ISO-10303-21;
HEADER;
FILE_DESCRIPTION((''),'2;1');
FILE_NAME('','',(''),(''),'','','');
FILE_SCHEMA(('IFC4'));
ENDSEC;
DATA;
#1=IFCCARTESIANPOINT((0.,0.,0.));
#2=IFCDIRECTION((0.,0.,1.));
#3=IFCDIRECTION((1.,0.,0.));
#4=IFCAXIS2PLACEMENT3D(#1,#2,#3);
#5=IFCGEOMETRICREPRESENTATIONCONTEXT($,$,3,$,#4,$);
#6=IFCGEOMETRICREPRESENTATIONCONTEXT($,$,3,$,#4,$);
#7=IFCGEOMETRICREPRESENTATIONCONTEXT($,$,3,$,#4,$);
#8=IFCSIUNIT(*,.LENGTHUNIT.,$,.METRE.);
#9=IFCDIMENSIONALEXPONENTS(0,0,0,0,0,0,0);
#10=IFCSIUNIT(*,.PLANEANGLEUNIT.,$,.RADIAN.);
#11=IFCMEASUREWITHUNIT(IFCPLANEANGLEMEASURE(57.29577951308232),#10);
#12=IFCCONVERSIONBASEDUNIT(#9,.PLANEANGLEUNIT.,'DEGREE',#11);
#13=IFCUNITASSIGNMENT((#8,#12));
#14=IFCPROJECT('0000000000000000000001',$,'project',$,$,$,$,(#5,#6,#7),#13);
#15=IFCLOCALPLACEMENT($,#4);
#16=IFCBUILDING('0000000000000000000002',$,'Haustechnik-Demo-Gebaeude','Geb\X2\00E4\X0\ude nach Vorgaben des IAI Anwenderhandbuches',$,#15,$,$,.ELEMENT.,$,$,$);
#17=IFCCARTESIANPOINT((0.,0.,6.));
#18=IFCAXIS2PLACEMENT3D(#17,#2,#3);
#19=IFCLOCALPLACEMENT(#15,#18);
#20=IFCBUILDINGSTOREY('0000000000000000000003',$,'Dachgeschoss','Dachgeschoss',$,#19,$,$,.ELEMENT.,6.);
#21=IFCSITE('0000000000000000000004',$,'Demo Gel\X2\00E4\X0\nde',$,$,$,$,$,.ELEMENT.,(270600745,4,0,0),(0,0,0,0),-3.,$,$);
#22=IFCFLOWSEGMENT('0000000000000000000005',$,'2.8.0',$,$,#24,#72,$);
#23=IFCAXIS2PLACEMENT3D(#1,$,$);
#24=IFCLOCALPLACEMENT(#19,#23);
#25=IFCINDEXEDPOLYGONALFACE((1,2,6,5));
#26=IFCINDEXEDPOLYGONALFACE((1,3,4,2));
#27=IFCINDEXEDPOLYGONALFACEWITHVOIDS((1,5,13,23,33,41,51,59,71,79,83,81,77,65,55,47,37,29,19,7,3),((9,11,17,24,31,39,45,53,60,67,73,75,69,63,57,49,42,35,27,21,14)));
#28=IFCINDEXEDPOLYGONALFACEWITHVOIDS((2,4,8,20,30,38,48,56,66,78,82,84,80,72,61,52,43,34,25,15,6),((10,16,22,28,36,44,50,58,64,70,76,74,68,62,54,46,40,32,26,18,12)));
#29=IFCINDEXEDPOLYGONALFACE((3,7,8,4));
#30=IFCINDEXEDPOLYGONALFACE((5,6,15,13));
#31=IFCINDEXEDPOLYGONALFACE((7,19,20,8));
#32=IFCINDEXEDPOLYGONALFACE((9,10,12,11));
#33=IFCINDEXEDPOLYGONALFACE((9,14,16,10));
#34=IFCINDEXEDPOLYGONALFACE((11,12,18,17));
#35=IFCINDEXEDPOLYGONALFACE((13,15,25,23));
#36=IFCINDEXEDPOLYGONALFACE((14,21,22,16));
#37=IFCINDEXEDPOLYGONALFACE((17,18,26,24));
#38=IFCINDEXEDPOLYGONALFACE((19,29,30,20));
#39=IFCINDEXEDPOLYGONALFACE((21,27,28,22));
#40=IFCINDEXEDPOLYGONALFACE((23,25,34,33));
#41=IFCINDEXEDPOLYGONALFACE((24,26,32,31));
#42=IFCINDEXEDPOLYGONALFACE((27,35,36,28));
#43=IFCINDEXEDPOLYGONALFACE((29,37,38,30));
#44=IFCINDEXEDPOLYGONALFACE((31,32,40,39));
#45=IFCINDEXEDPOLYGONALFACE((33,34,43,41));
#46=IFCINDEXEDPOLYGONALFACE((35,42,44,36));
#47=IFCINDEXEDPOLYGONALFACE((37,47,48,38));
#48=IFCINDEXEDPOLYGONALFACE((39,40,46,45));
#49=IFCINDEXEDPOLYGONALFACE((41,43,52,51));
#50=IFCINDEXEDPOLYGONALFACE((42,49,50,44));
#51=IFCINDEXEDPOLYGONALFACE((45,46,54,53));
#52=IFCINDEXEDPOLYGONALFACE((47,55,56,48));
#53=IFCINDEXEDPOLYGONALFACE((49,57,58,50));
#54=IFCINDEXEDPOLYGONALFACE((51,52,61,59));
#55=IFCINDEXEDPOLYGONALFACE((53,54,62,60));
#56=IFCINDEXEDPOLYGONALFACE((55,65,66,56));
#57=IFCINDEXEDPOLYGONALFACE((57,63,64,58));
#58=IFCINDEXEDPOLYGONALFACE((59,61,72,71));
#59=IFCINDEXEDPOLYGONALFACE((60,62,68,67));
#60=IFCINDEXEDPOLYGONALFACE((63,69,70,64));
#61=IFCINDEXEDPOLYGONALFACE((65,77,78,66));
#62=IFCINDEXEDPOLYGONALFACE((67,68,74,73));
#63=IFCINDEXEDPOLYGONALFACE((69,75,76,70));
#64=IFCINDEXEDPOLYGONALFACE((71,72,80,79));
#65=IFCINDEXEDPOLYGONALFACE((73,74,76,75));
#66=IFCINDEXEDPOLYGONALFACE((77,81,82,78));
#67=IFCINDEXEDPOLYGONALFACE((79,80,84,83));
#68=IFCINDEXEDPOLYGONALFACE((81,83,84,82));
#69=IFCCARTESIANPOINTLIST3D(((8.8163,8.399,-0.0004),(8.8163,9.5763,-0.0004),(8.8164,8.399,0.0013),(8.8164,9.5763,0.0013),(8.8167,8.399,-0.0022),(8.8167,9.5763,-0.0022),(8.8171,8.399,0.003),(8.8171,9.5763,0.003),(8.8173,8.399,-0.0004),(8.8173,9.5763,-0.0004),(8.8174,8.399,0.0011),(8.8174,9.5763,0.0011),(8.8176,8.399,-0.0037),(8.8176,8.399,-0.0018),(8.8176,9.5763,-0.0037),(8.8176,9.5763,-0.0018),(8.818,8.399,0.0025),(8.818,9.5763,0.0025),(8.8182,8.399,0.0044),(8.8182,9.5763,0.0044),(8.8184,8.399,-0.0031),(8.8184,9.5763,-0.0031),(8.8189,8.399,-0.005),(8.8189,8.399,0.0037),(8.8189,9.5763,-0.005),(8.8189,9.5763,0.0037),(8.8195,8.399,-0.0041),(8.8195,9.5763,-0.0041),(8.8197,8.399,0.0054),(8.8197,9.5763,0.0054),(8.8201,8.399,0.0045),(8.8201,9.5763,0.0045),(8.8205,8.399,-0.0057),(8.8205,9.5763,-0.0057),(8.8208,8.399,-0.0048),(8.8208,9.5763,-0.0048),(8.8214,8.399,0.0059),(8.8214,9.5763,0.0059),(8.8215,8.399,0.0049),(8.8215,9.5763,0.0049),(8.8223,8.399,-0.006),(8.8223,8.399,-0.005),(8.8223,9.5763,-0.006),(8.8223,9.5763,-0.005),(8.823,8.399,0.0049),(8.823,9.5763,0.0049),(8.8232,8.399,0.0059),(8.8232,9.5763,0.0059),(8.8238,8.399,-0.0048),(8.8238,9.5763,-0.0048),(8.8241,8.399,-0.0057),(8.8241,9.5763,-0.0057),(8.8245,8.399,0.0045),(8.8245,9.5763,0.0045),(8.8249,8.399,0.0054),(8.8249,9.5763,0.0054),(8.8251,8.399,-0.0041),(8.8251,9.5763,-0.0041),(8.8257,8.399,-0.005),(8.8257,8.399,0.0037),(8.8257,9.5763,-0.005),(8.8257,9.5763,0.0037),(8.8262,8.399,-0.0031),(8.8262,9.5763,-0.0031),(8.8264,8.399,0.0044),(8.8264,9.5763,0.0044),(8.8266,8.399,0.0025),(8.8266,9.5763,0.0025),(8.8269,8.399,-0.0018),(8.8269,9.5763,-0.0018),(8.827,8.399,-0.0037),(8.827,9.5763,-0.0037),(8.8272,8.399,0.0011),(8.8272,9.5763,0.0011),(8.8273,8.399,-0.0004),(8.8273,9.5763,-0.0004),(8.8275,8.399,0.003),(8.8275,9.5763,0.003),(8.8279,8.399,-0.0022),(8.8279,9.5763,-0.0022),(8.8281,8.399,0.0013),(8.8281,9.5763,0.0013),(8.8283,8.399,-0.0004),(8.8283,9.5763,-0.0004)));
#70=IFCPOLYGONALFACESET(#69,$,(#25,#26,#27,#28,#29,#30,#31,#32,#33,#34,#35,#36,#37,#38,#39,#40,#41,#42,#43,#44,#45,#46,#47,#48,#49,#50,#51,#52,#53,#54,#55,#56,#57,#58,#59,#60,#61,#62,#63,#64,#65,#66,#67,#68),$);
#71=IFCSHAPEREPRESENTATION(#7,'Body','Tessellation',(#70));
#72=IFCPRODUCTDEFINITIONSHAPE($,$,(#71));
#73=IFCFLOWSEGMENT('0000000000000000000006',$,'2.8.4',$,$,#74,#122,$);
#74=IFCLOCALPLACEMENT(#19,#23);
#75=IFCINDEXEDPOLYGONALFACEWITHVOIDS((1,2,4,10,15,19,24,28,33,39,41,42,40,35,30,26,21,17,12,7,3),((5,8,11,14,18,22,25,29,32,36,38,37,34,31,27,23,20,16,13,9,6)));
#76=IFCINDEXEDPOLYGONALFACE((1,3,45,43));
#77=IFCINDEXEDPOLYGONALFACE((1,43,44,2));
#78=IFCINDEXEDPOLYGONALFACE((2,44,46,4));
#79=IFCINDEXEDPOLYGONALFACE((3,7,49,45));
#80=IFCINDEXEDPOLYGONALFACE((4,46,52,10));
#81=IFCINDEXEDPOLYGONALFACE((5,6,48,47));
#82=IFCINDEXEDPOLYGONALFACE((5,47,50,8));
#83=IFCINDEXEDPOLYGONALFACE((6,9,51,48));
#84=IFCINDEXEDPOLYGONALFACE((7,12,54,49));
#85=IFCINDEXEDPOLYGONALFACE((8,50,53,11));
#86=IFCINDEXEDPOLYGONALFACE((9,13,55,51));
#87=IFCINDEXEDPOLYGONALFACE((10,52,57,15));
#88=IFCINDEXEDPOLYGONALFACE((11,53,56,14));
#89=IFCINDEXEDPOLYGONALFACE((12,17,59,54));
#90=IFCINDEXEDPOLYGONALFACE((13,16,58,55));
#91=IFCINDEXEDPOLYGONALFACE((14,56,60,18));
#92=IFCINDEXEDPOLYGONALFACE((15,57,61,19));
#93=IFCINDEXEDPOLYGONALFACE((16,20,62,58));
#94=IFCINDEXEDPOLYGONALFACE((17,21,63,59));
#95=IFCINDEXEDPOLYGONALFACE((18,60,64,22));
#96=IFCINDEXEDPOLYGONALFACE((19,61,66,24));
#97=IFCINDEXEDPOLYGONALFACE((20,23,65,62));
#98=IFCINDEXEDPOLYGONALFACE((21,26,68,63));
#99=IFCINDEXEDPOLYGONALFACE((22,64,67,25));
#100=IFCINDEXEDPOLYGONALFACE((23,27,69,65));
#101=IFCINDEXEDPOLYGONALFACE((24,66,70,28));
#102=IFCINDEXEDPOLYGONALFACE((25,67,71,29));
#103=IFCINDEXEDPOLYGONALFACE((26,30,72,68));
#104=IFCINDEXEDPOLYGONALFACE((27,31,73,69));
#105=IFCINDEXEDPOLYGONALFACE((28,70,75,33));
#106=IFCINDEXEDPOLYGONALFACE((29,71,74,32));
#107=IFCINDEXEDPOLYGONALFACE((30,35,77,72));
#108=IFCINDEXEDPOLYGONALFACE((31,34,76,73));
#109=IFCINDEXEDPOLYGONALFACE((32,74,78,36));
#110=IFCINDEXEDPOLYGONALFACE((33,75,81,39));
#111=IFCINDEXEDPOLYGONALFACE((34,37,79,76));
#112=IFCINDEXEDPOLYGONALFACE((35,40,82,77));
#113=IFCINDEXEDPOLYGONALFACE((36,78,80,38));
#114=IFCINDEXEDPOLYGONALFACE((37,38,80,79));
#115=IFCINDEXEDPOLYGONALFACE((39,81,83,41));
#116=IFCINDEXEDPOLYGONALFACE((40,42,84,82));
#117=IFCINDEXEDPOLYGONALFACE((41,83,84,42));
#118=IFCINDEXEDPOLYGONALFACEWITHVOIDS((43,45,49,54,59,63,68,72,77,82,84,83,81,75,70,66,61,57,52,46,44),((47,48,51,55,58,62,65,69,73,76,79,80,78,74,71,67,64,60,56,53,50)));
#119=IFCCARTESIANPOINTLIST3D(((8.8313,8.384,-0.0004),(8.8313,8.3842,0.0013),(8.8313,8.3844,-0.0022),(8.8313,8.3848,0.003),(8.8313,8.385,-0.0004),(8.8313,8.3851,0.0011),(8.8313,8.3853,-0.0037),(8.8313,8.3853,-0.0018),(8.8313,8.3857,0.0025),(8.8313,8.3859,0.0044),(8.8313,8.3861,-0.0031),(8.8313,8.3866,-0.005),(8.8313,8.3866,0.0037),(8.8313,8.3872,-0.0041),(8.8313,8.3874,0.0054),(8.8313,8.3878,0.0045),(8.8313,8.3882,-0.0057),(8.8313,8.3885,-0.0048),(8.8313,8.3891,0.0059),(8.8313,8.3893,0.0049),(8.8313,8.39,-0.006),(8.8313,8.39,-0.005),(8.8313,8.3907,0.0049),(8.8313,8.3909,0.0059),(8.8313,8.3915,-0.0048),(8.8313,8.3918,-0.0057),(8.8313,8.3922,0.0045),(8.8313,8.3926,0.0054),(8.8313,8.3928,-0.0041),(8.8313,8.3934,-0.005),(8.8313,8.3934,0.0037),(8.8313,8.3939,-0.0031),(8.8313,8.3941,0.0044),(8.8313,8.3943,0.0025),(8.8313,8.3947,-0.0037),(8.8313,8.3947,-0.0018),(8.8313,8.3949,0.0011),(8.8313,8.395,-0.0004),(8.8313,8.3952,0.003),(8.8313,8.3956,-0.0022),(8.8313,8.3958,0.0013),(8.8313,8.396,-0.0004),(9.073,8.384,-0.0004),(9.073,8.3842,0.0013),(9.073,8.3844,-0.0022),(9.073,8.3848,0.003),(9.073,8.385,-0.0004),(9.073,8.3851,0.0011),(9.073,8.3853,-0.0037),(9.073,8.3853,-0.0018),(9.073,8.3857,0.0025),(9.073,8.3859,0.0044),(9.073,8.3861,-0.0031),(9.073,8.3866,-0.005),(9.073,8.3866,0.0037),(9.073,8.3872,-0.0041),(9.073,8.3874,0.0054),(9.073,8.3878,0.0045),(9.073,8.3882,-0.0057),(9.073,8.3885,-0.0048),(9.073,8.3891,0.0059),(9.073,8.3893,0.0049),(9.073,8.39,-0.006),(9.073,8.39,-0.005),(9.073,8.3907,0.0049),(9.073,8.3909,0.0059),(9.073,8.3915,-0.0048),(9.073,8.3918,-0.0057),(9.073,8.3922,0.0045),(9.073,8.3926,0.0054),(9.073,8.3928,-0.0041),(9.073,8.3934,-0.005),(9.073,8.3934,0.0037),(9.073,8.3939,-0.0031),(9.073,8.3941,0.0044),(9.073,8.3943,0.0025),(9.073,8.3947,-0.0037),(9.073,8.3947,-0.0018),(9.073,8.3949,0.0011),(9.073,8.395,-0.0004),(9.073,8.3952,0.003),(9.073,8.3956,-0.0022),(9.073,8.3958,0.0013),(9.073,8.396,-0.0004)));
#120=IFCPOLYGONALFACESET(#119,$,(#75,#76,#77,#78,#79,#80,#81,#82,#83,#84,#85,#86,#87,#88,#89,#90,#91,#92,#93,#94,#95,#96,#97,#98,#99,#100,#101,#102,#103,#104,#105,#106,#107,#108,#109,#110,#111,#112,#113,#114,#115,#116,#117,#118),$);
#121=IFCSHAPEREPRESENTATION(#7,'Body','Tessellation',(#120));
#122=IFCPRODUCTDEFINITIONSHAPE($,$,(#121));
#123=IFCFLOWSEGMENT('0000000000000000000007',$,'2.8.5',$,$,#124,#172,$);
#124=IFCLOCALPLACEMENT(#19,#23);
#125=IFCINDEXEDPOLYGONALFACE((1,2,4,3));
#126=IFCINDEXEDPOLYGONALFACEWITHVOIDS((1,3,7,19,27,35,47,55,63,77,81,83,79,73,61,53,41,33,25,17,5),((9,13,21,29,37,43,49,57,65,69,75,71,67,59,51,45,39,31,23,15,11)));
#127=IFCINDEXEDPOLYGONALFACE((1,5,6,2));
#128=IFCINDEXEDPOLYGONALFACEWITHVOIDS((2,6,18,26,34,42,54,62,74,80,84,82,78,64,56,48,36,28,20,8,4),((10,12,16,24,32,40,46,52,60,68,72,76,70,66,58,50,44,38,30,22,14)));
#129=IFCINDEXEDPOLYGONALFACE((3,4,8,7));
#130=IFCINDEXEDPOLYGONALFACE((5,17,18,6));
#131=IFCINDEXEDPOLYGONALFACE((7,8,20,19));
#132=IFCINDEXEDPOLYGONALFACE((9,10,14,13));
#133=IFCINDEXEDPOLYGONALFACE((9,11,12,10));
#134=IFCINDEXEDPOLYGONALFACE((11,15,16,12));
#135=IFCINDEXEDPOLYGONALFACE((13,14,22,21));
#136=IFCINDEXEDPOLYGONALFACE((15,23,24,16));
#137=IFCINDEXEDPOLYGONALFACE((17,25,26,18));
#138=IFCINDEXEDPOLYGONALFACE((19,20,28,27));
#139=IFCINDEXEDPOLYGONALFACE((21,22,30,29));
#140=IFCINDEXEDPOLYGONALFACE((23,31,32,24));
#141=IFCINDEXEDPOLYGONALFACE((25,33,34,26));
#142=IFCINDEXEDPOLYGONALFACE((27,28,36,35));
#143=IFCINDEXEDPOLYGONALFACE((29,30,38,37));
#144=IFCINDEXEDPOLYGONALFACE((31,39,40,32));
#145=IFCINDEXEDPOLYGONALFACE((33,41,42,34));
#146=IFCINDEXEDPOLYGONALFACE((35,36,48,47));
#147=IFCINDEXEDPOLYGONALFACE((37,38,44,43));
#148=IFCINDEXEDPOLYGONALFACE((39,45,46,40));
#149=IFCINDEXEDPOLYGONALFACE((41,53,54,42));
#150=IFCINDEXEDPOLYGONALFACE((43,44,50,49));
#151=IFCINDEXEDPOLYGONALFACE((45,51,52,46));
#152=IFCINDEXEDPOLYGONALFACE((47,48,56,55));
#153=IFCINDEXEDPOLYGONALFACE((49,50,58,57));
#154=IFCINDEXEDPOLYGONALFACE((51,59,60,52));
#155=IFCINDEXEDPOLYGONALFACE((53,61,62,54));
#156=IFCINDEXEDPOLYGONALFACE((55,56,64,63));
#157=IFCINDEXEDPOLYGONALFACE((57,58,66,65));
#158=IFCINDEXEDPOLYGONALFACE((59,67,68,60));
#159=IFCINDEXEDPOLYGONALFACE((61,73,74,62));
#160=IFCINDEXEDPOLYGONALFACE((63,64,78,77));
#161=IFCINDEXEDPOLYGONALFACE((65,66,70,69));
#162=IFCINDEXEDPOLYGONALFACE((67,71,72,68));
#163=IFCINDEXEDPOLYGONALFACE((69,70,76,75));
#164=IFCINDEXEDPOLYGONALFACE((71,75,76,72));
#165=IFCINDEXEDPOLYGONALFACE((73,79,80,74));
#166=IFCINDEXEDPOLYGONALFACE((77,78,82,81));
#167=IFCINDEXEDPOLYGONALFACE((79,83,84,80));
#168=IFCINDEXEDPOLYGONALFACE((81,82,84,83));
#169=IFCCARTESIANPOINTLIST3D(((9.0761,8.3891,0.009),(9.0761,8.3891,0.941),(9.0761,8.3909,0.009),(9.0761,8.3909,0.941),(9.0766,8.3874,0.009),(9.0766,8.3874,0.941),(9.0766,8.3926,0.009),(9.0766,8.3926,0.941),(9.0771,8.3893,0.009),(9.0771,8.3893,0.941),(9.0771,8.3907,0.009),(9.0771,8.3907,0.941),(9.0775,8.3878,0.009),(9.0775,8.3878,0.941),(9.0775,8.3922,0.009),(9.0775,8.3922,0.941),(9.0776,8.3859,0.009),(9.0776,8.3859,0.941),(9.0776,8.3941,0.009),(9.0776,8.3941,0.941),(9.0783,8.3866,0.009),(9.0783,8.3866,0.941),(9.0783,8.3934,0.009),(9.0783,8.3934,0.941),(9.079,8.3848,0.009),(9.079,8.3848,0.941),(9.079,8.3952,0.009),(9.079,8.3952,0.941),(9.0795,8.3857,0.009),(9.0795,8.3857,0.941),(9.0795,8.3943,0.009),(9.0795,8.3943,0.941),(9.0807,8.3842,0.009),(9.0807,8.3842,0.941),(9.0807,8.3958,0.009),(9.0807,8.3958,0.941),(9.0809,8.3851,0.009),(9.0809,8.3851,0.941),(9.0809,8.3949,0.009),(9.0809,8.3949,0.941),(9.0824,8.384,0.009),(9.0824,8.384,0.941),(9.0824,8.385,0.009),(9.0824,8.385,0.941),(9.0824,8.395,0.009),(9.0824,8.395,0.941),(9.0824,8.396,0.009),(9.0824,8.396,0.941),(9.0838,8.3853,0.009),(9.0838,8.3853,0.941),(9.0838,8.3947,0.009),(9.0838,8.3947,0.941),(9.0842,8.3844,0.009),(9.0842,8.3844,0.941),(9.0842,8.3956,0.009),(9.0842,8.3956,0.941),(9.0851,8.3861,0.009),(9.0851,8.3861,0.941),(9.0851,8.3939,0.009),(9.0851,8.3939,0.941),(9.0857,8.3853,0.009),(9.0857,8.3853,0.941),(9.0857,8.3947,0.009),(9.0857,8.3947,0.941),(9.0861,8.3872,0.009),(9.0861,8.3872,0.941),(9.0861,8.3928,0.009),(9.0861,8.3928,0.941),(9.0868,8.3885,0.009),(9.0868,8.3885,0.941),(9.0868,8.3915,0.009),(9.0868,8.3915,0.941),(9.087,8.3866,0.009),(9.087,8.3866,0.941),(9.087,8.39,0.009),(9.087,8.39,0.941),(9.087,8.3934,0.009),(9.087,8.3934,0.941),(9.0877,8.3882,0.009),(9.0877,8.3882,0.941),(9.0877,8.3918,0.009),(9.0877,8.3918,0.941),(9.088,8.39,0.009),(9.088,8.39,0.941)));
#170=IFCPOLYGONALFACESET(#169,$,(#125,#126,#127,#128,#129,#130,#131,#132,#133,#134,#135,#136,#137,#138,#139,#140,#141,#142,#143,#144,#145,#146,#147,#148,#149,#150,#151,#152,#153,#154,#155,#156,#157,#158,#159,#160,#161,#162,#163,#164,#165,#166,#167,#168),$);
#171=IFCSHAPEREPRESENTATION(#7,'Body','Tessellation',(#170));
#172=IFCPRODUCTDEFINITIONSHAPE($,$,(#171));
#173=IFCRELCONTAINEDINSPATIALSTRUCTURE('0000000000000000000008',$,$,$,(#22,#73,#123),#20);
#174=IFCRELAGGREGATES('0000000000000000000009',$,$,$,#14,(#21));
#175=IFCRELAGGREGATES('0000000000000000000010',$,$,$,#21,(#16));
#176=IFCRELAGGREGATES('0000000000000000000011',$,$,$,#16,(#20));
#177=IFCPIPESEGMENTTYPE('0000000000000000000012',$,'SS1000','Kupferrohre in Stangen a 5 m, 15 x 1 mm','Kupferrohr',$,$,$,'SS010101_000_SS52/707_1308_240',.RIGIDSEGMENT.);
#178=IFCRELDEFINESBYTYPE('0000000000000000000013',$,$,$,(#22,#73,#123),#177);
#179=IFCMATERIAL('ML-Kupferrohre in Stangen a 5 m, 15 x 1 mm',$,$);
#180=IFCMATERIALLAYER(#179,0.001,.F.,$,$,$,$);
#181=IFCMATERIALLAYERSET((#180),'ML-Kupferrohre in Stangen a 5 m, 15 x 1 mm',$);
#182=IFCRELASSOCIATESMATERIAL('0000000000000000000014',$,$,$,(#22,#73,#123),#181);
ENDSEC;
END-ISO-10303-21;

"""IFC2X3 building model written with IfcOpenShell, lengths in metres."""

from ifc_helpers import new_model, entity, si_unit, converted_unit, frame, origin_with_axes, origin_2d_with_axis, place, context, project, spatial, hollow_circle, extrude, material, layer, layer_set, layer_usage, type_object, element, save


model = new_model("IFC2X3")

# Units and contexts
context_of_model_1 = context(None, 3, world=origin_with_axes())
context_of_model_2 = context(None, 3, world=origin_with_axes())
context_of_model_3 = context(None, 3, world=origin_with_axes())
ifc_project = project(units=[si_unit("LENGTHUNIT", "METRE"), converted_unit("PLANEANGLEUNIT", "DEGREE", entity("IfcPlaneAngleMeasure", 57.29577951308232), si_unit("PLANEANGLEUNIT", "RADIAN"), dimensions=[0, 0, 0, 0, 0, 0, 0])], contexts=[context_of_model_1, context_of_model_2, context_of_model_3])

# Site, building, storey
site = spatial("IfcSite", under=ifc_project, Name="Demo Gelände", CompositionType="ELEMENT", RefLatitude=(270600745, 4, 0, 0), RefLongitude=(0, 0, 0, 0), RefElevation=-3.0)
building_placement = place(None, origin_with_axes())
building = spatial("IfcBuilding", under=site, at=building_placement, Name="Haustechnik-Demo-Gebaeude", Description="Gebäude nach Vorgaben des IAI Anwenderhandbuches", CompositionType="ELEMENT")
storey_placement = place(building_placement, frame((0.0, 0.0, 6.0), z_axis=(0.0, 0.0, 1.0), x_axis=(1.0, 0.0, 0.0)))
storey = spatial("IfcBuildingStorey", under=building, at=storey_placement, Name="Dachgeschoss", Description="Dachgeschoss", CompositionType="ELEMENT", Elevation=6.0)

# Flow segments
ifc_material = material(Name="ML-Kupferrohre in Stangen a 5 m, 15 x 1 mm")
ifc_layer = layer(ifc_material, 0.001, ventilated=False)
ifc_layer_set = layer_set([ifc_layer], Name="ML-Kupferrohre in Stangen a 5 m, 15 x 1 mm")
ifc_layer_usage = layer_usage(ifc_layer_set, "AXIS2", "POSITIVE", 0.0)
pipe_segment_type_1 = type_object("IfcPipeSegmentType", Name="SS1000", Description="Kupferrohre in Stangen a 5 m, 15 x 1 mm", ApplicableOccurrence="Kupferrohr", ElementType="SS010101_000_SS52/707_1308_240", PredefinedType="RIGIDSEGMENT")
flow_segment_1_placement = place(storey_placement, frame((8.8223, 9.5763, 0.0), z_axis=(0.0, -1.0, 0.0), x_axis=(0.0, 0.0, -1.0)))
element("IfcFlowSegment", 1, at=flow_segment_1_placement, inside=storey, type_object=pipe_segment_type_1, material=ifc_layer_usage, Name="2.8.0", context=context_of_model_3, shape_type="SweptSolid", body=[
    extrude(hollow_circle(Radius=0.006, WallThickness=0.001, at=origin_2d_with_axis()), origin_with_axes(), (0.0, 0.0, 1.0), 1.1773),
])
flow_segment_2_placement = place(storey_placement, frame((8.8313, 8.39, 0.0), z_axis=(1.0, 0.0, 0.0), x_axis=(0.0, 0.0, -1.0)))
element("IfcFlowSegment", 2, at=flow_segment_2_placement, inside=storey, type_object=pipe_segment_type_1, material=ifc_layer_usage, Name="2.8.4", context=context_of_model_3, shape_type="SweptSolid", body=[
    extrude(hollow_circle(Radius=0.006, WallThickness=0.001, at=origin_2d_with_axis()), origin_with_axes(), (0.0, 0.0, 1.0), 0.2417),
])
flow_segment_3_placement = place(storey_placement, frame((9.082, 8.39, 0.009), z_axis=(0.0, 0.0, 1.0), x_axis=(1.0, 0.0, 0.0)))
element("IfcFlowSegment", 3, at=flow_segment_3_placement, inside=storey, type_object=pipe_segment_type_1, material=ifc_layer_usage, Name="2.8.5", context=context_of_model_3, shape_type="SweptSolid", body=[
    extrude(hollow_circle(Radius=0.006, WallThickness=0.001, at=origin_2d_with_axis()), origin_with_axes(), (0.0, 0.0, 1.0), 0.932),
])

save(model, "model.ifc")
